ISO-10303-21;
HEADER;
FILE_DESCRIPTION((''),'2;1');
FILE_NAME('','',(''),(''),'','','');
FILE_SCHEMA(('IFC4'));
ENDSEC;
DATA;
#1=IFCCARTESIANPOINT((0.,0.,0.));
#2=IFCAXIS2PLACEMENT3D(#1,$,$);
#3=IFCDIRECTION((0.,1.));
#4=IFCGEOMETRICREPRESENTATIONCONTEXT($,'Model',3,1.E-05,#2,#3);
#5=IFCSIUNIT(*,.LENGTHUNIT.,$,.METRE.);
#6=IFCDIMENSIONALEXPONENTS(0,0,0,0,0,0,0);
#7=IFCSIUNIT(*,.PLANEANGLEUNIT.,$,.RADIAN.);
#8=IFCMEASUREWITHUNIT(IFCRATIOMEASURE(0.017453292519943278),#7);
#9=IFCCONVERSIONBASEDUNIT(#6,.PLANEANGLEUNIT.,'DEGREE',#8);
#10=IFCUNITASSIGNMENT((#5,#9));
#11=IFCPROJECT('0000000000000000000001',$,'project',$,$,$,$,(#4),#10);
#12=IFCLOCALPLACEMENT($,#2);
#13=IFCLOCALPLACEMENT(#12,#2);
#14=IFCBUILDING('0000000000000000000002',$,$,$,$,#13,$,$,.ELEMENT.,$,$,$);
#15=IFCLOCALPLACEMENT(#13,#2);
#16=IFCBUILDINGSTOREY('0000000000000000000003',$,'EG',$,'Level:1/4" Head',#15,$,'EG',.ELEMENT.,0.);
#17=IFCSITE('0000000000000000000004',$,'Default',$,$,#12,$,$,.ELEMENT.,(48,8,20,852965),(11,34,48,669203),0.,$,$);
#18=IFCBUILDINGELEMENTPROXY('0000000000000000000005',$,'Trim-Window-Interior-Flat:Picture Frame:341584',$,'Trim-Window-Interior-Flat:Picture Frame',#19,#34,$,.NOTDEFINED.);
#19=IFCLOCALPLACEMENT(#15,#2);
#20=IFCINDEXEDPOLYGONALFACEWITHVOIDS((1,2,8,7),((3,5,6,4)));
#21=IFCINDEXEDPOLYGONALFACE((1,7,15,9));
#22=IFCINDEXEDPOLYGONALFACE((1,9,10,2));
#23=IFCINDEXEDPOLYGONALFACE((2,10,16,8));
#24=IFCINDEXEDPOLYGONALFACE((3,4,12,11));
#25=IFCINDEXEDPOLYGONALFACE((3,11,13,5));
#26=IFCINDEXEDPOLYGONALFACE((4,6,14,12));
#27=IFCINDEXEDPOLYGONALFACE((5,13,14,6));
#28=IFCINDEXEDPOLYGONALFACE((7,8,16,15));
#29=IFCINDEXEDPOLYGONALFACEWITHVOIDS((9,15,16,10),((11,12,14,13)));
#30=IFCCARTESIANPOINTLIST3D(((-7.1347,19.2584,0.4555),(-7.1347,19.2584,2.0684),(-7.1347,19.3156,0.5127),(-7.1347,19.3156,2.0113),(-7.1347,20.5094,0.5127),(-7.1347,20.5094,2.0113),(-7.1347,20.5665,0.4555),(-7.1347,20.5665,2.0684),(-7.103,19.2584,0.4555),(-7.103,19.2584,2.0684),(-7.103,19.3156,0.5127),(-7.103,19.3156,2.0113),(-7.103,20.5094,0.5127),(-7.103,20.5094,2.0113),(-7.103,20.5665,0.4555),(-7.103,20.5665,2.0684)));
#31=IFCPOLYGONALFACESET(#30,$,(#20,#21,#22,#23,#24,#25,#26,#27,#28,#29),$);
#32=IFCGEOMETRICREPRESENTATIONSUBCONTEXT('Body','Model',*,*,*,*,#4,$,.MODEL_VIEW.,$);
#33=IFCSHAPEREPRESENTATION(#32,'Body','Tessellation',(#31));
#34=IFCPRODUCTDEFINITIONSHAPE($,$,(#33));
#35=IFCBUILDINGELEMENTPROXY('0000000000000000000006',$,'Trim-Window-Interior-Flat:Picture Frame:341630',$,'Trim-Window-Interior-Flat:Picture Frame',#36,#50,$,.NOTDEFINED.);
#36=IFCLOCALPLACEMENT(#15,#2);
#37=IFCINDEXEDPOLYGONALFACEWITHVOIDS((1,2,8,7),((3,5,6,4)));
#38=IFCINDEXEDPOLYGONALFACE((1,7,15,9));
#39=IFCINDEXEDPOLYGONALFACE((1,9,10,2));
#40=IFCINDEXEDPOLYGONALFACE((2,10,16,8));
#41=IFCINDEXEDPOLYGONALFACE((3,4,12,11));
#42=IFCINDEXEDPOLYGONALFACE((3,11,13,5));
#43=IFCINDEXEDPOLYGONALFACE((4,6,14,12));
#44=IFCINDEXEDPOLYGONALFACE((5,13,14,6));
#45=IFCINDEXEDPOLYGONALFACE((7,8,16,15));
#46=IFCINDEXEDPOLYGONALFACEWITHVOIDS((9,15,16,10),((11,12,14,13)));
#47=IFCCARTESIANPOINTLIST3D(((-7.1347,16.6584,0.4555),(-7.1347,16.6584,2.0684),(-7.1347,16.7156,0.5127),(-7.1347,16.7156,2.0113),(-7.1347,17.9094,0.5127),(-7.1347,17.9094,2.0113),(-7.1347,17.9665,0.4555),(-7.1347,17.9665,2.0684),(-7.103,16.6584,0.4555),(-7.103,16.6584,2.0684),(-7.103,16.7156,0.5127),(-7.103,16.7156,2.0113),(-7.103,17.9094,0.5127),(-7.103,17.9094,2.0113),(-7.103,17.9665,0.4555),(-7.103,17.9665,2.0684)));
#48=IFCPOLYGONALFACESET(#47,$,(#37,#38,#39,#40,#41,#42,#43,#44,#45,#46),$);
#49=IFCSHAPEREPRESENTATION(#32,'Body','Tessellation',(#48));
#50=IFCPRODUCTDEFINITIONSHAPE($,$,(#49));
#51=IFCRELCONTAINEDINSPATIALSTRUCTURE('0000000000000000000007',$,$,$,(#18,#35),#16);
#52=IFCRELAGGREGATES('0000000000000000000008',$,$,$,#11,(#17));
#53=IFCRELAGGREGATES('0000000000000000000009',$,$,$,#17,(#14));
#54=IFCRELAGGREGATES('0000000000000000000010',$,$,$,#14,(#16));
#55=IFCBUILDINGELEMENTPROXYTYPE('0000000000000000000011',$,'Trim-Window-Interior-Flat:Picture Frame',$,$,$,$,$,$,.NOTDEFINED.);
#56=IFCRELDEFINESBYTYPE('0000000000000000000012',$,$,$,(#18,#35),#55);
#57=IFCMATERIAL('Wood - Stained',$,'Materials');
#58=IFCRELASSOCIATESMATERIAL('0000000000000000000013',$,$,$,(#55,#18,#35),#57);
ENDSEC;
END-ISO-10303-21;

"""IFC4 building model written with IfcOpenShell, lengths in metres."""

from ifc_helpers import new_model, entity, si_unit, converted_unit, direction, frame, origin, place, context, subcontext, project, spatial, indexed_curve, outline, extrude, source, transform, mapped, material, type_object, type_shapes, element, save


model = new_model("IFC4")

# Units and contexts
model_context = context("Model", 3, precision=1e-05, world=origin(), true_north=direction((0.0, 1.0)))
body_context = subcontext(model_context, "Body", "Model", "MODEL_VIEW")
ifc_project = project(units=[si_unit("LENGTHUNIT", "METRE"), converted_unit("PLANEANGLEUNIT", "DEGREE", entity("IfcRatioMeasure", 0.017453292519943278), si_unit("PLANEANGLEUNIT", "RADIAN"), dimensions=[0, 0, 0, 0, 0, 0, 0])], contexts=[model_context])

# Site, building, storey
site_placement = place(None, origin())
site = spatial("IfcSite", under=ifc_project, at=site_placement, Name="Default", CompositionType="ELEMENT", RefLatitude=(48, 8, 20, 852965), RefLongitude=(11, 34, 48, 669203), RefElevation=0.0)
building_placement = place(site_placement, origin())
building = spatial("IfcBuilding", under=site, at=building_placement, CompositionType="ELEMENT")
storey_placement = place(building_placement, origin())
storey = spatial("IfcBuildingStorey", under=building, at=storey_placement, Name="EG", ObjectType="Level:1/4\" Head", LongName="EG", CompositionType="ELEMENT", Elevation=0.0)

# Building element proxies
ifc_material_1 = material(Name="Wood - Stained", Category="Materials")
building_element_proxy_type_1 = type_object("IfcBuildingElementProxyType", Name="Trim-Window-Interior-Flat:Picture Frame", PredefinedType="NOTDEFINED", material=ifc_material_1)
shared_shape_1 = source(origin(), body_context, "Body", "SweptSolid", [
    extrude(outline(indexed_curve([(-0.654, -0.8064), (0.654, -0.8064), (0.654, 0.8064), (-0.654, 0.8064), (-0.654, -0.8064)], self_intersect=False), holes=[indexed_curve([(-0.5969, -0.7493), (-0.5969, 0.7493), (0.5969, 0.7493), (0.5969, -0.7493), (-0.5969, -0.7493)], self_intersect=False)]), frame((0.0, -0.762, 0.0), z_axis=(0.0, 0.0, 1.0), x_axis=(-1.0, 0.0, 0.0)), (0.0, 0.0, 1.0), 0.0317),
])
type_shapes(building_element_proxy_type_1, [shared_shape_1])
for number, where, z_axis, x_axis, name in (
    (1, (-7.103, 19.9125, 2.024), (-1.0, 0.0, 0.0), (0.0, -1.0, 0.0), "Trim-Window-Interior-Flat:Picture Frame:341584"),
    (2, (-7.103, 17.3125, 2.024), (-1.0, 0.0, 0.0), (0.0, -1.0, 0.0), "Trim-Window-Interior-Flat:Picture Frame:341630"),
):
    element("IfcBuildingElementProxy", number, at=place(storey_placement, frame(where, z_axis=z_axis, x_axis=x_axis)), inside=storey, type_object=building_element_proxy_type_1, material=ifc_material_1, Name=name, ObjectType="Trim-Window-Interior-Flat:Picture Frame", PredefinedType="NOTDEFINED", context=body_context, shape_type="MappedRepresentation", body=[
        mapped(shared_shape_1, transform((0.0, 0.0, 0.0), scale=1.0)),
    ])

save(model, "model.ifc")
